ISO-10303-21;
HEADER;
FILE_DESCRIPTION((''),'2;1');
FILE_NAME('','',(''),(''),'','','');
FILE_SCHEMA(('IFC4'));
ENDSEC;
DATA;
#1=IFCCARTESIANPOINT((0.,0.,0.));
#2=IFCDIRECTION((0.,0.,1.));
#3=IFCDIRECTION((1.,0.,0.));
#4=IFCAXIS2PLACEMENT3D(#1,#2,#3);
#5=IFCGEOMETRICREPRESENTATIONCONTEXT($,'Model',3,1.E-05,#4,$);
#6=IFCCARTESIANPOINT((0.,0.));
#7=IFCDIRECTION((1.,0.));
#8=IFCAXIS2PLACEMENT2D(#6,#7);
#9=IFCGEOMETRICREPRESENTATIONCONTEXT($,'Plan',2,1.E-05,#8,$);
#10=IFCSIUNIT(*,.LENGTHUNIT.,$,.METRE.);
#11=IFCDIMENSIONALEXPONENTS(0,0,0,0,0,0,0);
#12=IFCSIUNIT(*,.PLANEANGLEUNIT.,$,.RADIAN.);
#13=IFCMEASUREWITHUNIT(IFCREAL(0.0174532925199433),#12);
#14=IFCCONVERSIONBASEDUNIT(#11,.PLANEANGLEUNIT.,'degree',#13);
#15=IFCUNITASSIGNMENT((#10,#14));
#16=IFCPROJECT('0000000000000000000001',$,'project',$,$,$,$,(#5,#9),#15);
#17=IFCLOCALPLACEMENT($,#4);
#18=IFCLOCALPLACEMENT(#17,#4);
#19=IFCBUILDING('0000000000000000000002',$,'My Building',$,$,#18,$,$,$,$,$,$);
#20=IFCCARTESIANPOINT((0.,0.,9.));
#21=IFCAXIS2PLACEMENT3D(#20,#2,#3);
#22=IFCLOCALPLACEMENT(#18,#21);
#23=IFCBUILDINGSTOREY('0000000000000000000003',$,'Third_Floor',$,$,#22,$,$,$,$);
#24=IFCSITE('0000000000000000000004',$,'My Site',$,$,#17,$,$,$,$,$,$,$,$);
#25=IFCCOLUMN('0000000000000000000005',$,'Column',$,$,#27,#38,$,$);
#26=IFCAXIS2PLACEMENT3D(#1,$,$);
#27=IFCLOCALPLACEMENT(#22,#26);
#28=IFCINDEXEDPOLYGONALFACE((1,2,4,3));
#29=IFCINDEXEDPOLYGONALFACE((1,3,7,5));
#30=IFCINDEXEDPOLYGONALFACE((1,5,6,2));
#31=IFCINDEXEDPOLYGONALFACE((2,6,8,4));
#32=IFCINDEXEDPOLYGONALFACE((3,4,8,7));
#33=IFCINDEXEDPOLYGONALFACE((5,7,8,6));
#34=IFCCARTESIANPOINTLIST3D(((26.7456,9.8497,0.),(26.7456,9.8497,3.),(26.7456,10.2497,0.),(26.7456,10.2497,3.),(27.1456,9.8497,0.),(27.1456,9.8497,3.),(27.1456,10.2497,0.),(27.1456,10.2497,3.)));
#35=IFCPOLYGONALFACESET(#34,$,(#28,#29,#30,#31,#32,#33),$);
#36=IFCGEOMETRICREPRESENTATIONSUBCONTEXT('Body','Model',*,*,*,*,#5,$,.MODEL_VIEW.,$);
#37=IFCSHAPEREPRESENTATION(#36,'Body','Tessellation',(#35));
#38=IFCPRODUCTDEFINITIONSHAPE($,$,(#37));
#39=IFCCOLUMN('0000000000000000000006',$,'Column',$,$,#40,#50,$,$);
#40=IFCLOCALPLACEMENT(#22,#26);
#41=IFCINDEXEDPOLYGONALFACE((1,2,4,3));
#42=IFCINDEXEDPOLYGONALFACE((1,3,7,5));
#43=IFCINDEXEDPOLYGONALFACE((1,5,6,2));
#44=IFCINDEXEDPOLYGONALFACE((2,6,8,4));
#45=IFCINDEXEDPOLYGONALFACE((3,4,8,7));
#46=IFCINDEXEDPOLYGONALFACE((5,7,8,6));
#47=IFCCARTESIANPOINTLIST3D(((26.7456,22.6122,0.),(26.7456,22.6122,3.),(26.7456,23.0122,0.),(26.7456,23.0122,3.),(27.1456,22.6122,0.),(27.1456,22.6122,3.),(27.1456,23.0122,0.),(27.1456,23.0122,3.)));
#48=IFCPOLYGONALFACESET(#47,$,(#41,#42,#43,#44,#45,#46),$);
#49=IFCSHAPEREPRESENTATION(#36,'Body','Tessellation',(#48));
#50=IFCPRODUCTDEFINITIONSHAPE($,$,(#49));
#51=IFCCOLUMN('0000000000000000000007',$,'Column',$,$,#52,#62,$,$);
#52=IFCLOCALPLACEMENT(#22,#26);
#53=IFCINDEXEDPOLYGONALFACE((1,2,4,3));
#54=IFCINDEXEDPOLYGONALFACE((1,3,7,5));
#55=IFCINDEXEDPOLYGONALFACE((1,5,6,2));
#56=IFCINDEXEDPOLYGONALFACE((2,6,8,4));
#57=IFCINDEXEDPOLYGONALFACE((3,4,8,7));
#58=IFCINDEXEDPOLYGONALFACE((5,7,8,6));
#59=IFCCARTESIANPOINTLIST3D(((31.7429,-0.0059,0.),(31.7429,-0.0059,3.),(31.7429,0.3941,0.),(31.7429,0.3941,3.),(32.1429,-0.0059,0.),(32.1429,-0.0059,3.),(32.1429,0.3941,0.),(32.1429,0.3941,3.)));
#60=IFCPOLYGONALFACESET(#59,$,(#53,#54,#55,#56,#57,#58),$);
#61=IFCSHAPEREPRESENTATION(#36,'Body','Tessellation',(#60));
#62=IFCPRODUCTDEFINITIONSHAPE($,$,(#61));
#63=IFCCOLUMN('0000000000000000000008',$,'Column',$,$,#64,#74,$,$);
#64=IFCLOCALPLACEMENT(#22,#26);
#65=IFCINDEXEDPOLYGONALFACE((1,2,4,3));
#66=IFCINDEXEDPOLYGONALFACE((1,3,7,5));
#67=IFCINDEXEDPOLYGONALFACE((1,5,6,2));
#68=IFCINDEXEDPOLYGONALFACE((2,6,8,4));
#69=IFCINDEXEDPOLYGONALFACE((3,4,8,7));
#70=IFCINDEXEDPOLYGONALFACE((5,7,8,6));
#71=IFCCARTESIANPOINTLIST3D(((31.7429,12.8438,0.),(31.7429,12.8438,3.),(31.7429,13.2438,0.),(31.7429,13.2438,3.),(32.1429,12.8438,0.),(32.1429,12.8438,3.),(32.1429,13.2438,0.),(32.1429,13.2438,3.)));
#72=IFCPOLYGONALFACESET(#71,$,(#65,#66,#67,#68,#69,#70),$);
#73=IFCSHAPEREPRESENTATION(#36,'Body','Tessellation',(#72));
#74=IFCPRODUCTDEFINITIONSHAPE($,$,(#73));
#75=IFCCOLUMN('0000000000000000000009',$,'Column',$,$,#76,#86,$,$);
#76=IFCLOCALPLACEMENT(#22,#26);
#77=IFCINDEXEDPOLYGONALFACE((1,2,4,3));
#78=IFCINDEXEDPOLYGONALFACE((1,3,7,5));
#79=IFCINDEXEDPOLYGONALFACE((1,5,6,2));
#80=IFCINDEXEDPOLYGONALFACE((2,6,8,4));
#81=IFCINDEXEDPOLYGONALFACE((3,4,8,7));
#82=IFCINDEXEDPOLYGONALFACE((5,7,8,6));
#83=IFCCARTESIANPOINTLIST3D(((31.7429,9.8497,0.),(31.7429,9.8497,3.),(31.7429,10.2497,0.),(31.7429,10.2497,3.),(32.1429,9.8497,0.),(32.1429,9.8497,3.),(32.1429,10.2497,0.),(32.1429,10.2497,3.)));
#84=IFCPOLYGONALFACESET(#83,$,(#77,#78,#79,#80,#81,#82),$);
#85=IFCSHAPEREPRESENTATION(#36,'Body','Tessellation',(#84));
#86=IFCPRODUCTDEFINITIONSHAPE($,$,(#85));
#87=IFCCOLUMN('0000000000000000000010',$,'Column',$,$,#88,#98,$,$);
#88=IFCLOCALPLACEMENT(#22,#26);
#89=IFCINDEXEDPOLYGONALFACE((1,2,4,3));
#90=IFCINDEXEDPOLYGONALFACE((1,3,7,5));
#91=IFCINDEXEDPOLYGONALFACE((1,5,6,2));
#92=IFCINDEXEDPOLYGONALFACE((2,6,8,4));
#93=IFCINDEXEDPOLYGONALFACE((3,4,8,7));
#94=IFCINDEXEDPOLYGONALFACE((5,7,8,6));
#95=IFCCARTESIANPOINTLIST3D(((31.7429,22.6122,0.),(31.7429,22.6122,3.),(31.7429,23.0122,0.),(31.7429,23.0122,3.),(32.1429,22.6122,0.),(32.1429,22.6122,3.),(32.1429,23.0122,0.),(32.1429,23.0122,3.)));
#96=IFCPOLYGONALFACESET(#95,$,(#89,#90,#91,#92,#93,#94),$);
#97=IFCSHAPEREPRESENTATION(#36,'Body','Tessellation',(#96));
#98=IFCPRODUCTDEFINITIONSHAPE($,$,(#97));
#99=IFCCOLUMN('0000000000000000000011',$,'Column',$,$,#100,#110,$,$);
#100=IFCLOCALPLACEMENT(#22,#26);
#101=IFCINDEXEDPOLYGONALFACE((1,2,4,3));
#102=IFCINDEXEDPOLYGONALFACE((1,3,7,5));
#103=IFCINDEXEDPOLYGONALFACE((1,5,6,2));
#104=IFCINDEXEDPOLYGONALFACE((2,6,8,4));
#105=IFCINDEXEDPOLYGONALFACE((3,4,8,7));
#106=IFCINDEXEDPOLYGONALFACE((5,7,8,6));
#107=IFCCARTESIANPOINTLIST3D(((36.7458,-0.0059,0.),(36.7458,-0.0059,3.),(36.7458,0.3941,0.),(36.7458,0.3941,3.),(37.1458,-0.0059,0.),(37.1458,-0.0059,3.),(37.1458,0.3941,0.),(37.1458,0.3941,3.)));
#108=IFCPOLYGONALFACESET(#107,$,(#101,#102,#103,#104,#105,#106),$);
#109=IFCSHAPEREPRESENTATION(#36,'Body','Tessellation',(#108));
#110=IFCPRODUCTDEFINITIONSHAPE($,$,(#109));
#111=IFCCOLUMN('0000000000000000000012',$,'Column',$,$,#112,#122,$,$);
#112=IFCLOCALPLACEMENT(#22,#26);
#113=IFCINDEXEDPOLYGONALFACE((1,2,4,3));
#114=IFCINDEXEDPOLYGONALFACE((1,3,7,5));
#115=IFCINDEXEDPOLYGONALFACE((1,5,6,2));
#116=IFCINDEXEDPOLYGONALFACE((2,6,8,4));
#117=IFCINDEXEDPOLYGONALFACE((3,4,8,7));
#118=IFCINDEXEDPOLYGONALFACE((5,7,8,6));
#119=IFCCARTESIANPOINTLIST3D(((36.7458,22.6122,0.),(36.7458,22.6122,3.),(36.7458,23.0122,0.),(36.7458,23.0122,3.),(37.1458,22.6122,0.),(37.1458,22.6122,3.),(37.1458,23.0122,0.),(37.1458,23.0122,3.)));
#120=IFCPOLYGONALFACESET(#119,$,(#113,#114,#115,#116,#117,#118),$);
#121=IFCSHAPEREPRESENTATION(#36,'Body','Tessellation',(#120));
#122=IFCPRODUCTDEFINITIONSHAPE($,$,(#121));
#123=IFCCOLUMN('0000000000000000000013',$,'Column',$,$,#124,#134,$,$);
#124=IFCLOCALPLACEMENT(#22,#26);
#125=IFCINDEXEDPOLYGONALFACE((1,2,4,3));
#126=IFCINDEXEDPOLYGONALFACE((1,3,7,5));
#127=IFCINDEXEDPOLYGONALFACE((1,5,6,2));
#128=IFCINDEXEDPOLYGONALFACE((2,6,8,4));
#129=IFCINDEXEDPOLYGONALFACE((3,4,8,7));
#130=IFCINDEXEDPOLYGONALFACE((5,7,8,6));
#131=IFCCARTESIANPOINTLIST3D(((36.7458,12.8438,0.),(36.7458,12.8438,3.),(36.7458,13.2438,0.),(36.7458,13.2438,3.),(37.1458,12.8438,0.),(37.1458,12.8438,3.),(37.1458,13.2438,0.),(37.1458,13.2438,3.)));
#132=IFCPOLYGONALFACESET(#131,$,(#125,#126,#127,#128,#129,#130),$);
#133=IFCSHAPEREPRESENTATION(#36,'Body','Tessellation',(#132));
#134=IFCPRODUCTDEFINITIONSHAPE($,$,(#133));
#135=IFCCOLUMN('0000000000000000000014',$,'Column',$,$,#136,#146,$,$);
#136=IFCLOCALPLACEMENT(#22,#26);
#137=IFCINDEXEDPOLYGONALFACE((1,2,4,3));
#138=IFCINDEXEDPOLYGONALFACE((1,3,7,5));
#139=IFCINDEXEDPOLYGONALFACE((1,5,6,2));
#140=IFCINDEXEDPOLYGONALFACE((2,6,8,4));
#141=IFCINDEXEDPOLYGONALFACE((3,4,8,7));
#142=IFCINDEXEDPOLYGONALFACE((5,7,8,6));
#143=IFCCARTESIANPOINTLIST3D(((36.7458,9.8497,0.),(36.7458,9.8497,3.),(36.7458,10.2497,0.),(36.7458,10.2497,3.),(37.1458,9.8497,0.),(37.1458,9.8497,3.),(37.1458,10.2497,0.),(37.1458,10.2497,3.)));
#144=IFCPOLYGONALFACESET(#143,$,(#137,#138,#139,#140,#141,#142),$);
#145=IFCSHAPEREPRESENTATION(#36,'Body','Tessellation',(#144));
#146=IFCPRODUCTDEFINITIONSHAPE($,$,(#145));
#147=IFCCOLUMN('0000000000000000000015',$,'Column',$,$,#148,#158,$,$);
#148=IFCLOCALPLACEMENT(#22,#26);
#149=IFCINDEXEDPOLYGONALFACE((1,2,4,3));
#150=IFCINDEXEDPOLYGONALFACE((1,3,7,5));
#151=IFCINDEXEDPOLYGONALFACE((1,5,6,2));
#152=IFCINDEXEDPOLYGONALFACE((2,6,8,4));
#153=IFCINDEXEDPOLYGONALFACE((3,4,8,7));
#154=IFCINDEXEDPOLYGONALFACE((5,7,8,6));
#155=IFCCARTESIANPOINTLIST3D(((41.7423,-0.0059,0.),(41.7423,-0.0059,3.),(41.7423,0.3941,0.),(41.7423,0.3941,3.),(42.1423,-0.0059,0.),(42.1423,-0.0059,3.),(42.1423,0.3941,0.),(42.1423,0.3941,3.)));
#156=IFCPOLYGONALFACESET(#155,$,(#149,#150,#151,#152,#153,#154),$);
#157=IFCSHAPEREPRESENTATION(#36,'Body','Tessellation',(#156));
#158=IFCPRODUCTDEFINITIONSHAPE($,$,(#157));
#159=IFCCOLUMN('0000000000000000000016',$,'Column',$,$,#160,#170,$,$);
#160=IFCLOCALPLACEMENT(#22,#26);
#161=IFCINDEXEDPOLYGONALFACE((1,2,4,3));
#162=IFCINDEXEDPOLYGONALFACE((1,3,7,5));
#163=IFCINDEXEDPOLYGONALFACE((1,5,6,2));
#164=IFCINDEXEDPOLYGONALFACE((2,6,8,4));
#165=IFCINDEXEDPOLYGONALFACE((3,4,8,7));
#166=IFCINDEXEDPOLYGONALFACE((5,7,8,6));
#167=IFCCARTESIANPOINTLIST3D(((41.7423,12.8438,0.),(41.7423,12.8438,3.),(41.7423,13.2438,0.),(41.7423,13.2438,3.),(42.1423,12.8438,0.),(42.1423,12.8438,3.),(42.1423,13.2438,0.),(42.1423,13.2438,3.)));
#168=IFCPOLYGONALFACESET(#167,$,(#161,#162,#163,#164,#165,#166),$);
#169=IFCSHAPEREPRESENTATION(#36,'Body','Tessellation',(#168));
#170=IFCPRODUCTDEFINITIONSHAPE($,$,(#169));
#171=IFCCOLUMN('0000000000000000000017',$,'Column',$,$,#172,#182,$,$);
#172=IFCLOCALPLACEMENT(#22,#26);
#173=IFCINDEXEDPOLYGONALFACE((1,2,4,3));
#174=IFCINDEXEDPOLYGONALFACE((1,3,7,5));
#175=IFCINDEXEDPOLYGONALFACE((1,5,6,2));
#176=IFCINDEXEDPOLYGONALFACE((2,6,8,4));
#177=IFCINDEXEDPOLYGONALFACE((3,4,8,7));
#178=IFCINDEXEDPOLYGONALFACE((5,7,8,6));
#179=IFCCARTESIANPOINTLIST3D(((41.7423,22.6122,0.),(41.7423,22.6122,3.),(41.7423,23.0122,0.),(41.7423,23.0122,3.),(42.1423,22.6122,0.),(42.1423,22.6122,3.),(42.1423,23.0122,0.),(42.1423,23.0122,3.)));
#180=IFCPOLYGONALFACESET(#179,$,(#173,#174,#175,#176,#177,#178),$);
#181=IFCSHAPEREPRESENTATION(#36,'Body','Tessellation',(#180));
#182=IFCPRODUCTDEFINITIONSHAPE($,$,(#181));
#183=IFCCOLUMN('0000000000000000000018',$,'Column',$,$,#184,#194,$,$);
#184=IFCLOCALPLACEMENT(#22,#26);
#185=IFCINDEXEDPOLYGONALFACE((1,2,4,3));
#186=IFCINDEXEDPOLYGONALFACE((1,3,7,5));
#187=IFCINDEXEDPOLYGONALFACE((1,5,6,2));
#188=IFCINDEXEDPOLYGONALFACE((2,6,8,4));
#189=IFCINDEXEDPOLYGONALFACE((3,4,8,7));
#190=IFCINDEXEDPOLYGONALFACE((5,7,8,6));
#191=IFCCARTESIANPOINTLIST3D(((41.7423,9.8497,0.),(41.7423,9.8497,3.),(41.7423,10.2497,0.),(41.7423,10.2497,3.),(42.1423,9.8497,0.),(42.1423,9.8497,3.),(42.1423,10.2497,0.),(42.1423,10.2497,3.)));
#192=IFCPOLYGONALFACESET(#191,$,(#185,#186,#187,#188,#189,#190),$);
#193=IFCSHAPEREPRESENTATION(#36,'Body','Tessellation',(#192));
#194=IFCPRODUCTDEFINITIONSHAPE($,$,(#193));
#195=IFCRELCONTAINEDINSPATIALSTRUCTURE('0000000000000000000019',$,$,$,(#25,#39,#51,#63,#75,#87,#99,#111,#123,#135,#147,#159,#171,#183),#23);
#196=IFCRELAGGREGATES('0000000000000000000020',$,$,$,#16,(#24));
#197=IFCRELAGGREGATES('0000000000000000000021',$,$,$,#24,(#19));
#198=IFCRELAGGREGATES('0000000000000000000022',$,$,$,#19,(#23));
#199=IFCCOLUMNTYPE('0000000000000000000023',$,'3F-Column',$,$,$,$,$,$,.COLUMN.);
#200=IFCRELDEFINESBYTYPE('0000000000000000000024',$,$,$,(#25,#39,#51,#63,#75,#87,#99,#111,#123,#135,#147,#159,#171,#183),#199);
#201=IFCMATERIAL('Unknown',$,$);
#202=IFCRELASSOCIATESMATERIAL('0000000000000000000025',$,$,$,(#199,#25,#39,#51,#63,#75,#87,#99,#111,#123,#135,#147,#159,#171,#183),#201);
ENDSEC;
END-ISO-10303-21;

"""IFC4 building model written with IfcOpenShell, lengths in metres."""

from ifc_helpers import new_model, entity, si_unit, converted_unit, frame, origin_with_axes, origin_2d_with_axis, place, context, subcontext, project, spatial, rectangle, extrude, material, material_profile, profile_set, profile_usage, type_object, element, save


model = new_model("IFC4")

# Units and contexts
model_context = context("Model", 3, precision=1e-05, world=origin_with_axes())
plan_context = context("Plan", 2, precision=1e-05, world=origin_2d_with_axis())
body_context = subcontext(model_context, "Body", "Model", "MODEL_VIEW")
ifc_project = project(units=[si_unit("LENGTHUNIT", "METRE"), converted_unit("PLANEANGLEUNIT", "degree", entity("IfcReal", 0.0174532925199433), si_unit("PLANEANGLEUNIT", "RADIAN"), dimensions=[0, 0, 0, 0, 0, 0, 0])], contexts=[model_context, plan_context])

# Site, building, storey
site_placement = place(None, origin_with_axes())
site = spatial("IfcSite", under=ifc_project, at=site_placement, Name="My Site")
building_placement = place(site_placement, origin_with_axes())
building = spatial("IfcBuilding", under=site, at=building_placement, Name="My Building")
storey_placement = place(building_placement, frame((0.0, 0.0, 9.0), z_axis=(0.0, 0.0, 1.0), x_axis=(1.0, 0.0, 0.0)))
storey = spatial("IfcBuildingStorey", under=building, at=storey_placement, Name="Third_Floor")

# Columns
ifc_material = material(Name="Unknown")
ifc_material_profile_1 = material_profile(ifc_material, rectangle(XDim=0.4, YDim=0.4))
ifc_profile_set_1 = profile_set([ifc_material_profile_1])
ifc_profile_usage_1 = profile_usage(ifc_profile_set_1, cardinal=8)
column_type = type_object("IfcColumnType", Name="3F-Column", PredefinedType="COLUMN", material=ifc_profile_set_1)
column_1_placement = place(storey_placement, frame((26.9456, 10.2497, 0.0), z_axis=(0.0, 0.0, 1.0), x_axis=(1.0, 0.0, 0.0)))
element("IfcColumn", 1, at=column_1_placement, inside=storey, type_object=column_type, material=ifc_profile_usage_1, Name="Column", context=body_context, shape_type="SweptSolid", body=[
    extrude(rectangle(XDim=0.4, YDim=0.4), frame((0.0, -0.2, 0.0), z_axis=(0.0, 0.0, 1.0), x_axis=(1.0, 0.0, 0.0)), (0.0, 0.0, 1.0), 3.0),
])
ifc_profile_usage_2 = profile_usage(ifc_profile_set_1, cardinal=8)
column_2_placement = place(storey_placement, frame((26.9456, 23.0122, 0.0), z_axis=(0.0, 0.0, 1.0), x_axis=(1.0, 0.0, 0.0)))
element("IfcColumn", 2, at=column_2_placement, inside=storey, type_object=column_type, material=ifc_profile_usage_2, Name="Column", context=body_context, shape_type="SweptSolid", body=[
    extrude(rectangle(XDim=0.4, YDim=0.4), frame((0.0, -0.2, 0.0), z_axis=(0.0, 0.0, 1.0), x_axis=(1.0, 0.0, 0.0)), (0.0, 0.0, 1.0), 3.0),
])
ifc_profile_usage_3 = profile_usage(ifc_profile_set_1, cardinal=8)
column_3_placement = place(storey_placement, frame((31.9429, 0.3941, 0.0), z_axis=(0.0, 0.0, 1.0), x_axis=(1.0, 0.0, 0.0)))
element("IfcColumn", 3, at=column_3_placement, inside=storey, type_object=column_type, material=ifc_profile_usage_3, Name="Column", context=body_context, shape_type="SweptSolid", body=[
    extrude(rectangle(XDim=0.4, YDim=0.4), frame((0.0, -0.2, 0.0), z_axis=(0.0, 0.0, 1.0), x_axis=(1.0, 0.0, 0.0)), (0.0, 0.0, 1.0), 3.0),
])
ifc_profile_usage_4 = profile_usage(ifc_profile_set_1, cardinal=8)
column_4_placement = place(storey_placement, frame((31.9429, 13.2438, 0.0), z_axis=(0.0, 0.0, 1.0), x_axis=(1.0, 0.0, 0.0)))
element("IfcColumn", 4, at=column_4_placement, inside=storey, type_object=column_type, material=ifc_profile_usage_4, Name="Column", context=body_context, shape_type="SweptSolid", body=[
    extrude(rectangle(XDim=0.4, YDim=0.4), frame((0.0, -0.2, 0.0), z_axis=(0.0, 0.0, 1.0), x_axis=(1.0, 0.0, 0.0)), (0.0, 0.0, 1.0), 3.0),
])
ifc_profile_usage_5 = profile_usage(ifc_profile_set_1, cardinal=8)
column_5_placement = place(storey_placement, frame((31.9429, 10.2497, 0.0), z_axis=(0.0, 0.0, 1.0), x_axis=(1.0, 0.0, 0.0)))
element("IfcColumn", 5, at=column_5_placement, inside=storey, type_object=column_type, material=ifc_profile_usage_5, Name="Column", context=body_context, shape_type="SweptSolid", body=[
    extrude(rectangle(XDim=0.4, YDim=0.4), frame((0.0, -0.2, 0.0), z_axis=(0.0, 0.0, 1.0), x_axis=(1.0, 0.0, 0.0)), (0.0, 0.0, 1.0), 3.0),
])
ifc_profile_usage_6 = profile_usage(ifc_profile_set_1, cardinal=8)
column_6_placement = place(storey_placement, frame((31.9429, 23.0122, 0.0), z_axis=(0.0, 0.0, 1.0), x_axis=(1.0, 0.0, 0.0)))
element("IfcColumn", 6, at=column_6_placement, inside=storey, type_object=column_type, material=ifc_profile_usage_6, Name="Column", context=body_context, shape_type="SweptSolid", body=[
    extrude(rectangle(XDim=0.4, YDim=0.4), frame((0.0, -0.2, 0.0), z_axis=(0.0, 0.0, 1.0), x_axis=(1.0, 0.0, 0.0)), (0.0, 0.0, 1.0), 3.0),
])
ifc_profile_usage_7 = profile_usage(ifc_profile_set_1, cardinal=8)
column_7_placement = place(storey_placement, frame((36.9458, 0.3941, 0.0), z_axis=(0.0, 0.0, 1.0), x_axis=(1.0, 0.0, 0.0)))
element("IfcColumn", 7, at=column_7_placement, inside=storey, type_object=column_type, material=ifc_profile_usage_7, Name="Column", context=body_context, shape_type="SweptSolid", body=[
    extrude(rectangle(XDim=0.4, YDim=0.4), frame((0.0, -0.2, 0.0), z_axis=(0.0, 0.0, 1.0), x_axis=(1.0, 0.0, 0.0)), (0.0, 0.0, 1.0), 3.0),
])
ifc_profile_usage_8 = profile_usage(ifc_profile_set_1, cardinal=8)
column_8_placement = place(storey_placement, frame((36.9458, 23.0122, 0.0), z_axis=(0.0, 0.0, 1.0), x_axis=(1.0, 0.0, 0.0)))
element("IfcColumn", 8, at=column_8_placement, inside=storey, type_object=column_type, material=ifc_profile_usage_8, Name="Column", context=body_context, shape_type="SweptSolid", body=[
    extrude(rectangle(XDim=0.4, YDim=0.4), frame((0.0, -0.2, 0.0), z_axis=(0.0, 0.0, 1.0), x_axis=(1.0, 0.0, 0.0)), (0.0, 0.0, 1.0), 3.0),
])
ifc_profile_usage_9 = profile_usage(ifc_profile_set_1, cardinal=8)
column_9_placement = place(storey_placement, frame((36.9458, 13.2438, 0.0), z_axis=(0.0, 0.0, 1.0), x_axis=(1.0, 0.0, 0.0)))
element("IfcColumn", 9, at=column_9_placement, inside=storey, type_object=column_type, material=ifc_profile_usage_9, Name="Column", context=body_context, shape_type="SweptSolid", body=[
    extrude(rectangle(XDim=0.4, YDim=0.4), frame((0.0, -0.2, 0.0), z_axis=(0.0, 0.0, 1.0), x_axis=(1.0, 0.0, 0.0)), (0.0, 0.0, 1.0), 3.0),
])
ifc_profile_usage_10 = profile_usage(ifc_profile_set_1, cardinal=8)
column_10_placement = place(storey_placement, frame((36.9458, 10.2497, 0.0), z_axis=(0.0, 0.0, 1.0), x_axis=(1.0, 0.0, 0.0)))
element("IfcColumn", 10, at=column_10_placement, inside=storey, type_object=column_type, material=ifc_profile_usage_10, Name="Column", context=body_context, shape_type="SweptSolid", body=[
    extrude(rectangle(XDim=0.4, YDim=0.4), frame((0.0, -0.2, 0.0), z_axis=(0.0, 0.0, 1.0), x_axis=(1.0, 0.0, 0.0)), (0.0, 0.0, 1.0), 3.0),
])
ifc_profile_usage_11 = profile_usage(ifc_profile_set_1, cardinal=8)
column_11_placement = place(storey_placement, frame((41.9423, 0.3941, 0.0), z_axis=(0.0, 0.0, 1.0), x_axis=(1.0, 0.0, 0.0)))
element("IfcColumn", 11, at=column_11_placement, inside=storey, type_object=column_type, material=ifc_profile_usage_11, Name="Column", context=body_context, shape_type="SweptSolid", body=[
    extrude(rectangle(XDim=0.4, YDim=0.4), frame((0.0, -0.2, 0.0), z_axis=(0.0, 0.0, 1.0), x_axis=(1.0, 0.0, 0.0)), (0.0, 0.0, 1.0), 3.0),
])
ifc_profile_usage_12 = profile_usage(ifc_profile_set_1, cardinal=8)
column_12_placement = place(storey_placement, frame((41.9423, 13.2438, 0.0), z_axis=(0.0, 0.0, 1.0), x_axis=(1.0, 0.0, 0.0)))
element("IfcColumn", 12, at=column_12_placement, inside=storey, type_object=column_type, material=ifc_profile_usage_12, Name="Column", context=body_context, shape_type="SweptSolid", body=[
    extrude(rectangle(XDim=0.4, YDim=0.4), frame((0.0, -0.2, 0.0), z_axis=(0.0, 0.0, 1.0), x_axis=(1.0, 0.0, 0.0)), (0.0, 0.0, 1.0), 3.0),
])
ifc_profile_usage_13 = profile_usage(ifc_profile_set_1, cardinal=8)
column_13_placement = place(storey_placement, frame((41.9423, 23.0122, 0.0), z_axis=(0.0, 0.0, 1.0), x_axis=(1.0, 0.0, 0.0)))
element("IfcColumn", 13, at=column_13_placement, inside=storey, type_object=column_type, material=ifc_profile_usage_13, Name="Column", context=body_context, shape_type="SweptSolid", body=[
    extrude(rectangle(XDim=0.4, YDim=0.4), frame((0.0, -0.2, 0.0), z_axis=(0.0, 0.0, 1.0), x_axis=(1.0, 0.0, 0.0)), (0.0, 0.0, 1.0), 3.0),
])
ifc_profile_usage_14 = profile_usage(ifc_profile_set_1, cardinal=8)
column_14_placement = place(storey_placement, frame((41.9423, 10.2497, 0.0), z_axis=(0.0, 0.0, 1.0), x_axis=(1.0, 0.0, 0.0)))
element("IfcColumn", 14, at=column_14_placement, inside=storey, type_object=column_type, material=ifc_profile_usage_14, Name="Column", context=body_context, shape_type="SweptSolid", body=[
    extrude(rectangle(XDim=0.4, YDim=0.4), frame((0.0, -0.2, 0.0), z_axis=(0.0, 0.0, 1.0), x_axis=(1.0, 0.0, 0.0)), (0.0, 0.0, 1.0), 3.0),
])

save(model, "model.ifc")
